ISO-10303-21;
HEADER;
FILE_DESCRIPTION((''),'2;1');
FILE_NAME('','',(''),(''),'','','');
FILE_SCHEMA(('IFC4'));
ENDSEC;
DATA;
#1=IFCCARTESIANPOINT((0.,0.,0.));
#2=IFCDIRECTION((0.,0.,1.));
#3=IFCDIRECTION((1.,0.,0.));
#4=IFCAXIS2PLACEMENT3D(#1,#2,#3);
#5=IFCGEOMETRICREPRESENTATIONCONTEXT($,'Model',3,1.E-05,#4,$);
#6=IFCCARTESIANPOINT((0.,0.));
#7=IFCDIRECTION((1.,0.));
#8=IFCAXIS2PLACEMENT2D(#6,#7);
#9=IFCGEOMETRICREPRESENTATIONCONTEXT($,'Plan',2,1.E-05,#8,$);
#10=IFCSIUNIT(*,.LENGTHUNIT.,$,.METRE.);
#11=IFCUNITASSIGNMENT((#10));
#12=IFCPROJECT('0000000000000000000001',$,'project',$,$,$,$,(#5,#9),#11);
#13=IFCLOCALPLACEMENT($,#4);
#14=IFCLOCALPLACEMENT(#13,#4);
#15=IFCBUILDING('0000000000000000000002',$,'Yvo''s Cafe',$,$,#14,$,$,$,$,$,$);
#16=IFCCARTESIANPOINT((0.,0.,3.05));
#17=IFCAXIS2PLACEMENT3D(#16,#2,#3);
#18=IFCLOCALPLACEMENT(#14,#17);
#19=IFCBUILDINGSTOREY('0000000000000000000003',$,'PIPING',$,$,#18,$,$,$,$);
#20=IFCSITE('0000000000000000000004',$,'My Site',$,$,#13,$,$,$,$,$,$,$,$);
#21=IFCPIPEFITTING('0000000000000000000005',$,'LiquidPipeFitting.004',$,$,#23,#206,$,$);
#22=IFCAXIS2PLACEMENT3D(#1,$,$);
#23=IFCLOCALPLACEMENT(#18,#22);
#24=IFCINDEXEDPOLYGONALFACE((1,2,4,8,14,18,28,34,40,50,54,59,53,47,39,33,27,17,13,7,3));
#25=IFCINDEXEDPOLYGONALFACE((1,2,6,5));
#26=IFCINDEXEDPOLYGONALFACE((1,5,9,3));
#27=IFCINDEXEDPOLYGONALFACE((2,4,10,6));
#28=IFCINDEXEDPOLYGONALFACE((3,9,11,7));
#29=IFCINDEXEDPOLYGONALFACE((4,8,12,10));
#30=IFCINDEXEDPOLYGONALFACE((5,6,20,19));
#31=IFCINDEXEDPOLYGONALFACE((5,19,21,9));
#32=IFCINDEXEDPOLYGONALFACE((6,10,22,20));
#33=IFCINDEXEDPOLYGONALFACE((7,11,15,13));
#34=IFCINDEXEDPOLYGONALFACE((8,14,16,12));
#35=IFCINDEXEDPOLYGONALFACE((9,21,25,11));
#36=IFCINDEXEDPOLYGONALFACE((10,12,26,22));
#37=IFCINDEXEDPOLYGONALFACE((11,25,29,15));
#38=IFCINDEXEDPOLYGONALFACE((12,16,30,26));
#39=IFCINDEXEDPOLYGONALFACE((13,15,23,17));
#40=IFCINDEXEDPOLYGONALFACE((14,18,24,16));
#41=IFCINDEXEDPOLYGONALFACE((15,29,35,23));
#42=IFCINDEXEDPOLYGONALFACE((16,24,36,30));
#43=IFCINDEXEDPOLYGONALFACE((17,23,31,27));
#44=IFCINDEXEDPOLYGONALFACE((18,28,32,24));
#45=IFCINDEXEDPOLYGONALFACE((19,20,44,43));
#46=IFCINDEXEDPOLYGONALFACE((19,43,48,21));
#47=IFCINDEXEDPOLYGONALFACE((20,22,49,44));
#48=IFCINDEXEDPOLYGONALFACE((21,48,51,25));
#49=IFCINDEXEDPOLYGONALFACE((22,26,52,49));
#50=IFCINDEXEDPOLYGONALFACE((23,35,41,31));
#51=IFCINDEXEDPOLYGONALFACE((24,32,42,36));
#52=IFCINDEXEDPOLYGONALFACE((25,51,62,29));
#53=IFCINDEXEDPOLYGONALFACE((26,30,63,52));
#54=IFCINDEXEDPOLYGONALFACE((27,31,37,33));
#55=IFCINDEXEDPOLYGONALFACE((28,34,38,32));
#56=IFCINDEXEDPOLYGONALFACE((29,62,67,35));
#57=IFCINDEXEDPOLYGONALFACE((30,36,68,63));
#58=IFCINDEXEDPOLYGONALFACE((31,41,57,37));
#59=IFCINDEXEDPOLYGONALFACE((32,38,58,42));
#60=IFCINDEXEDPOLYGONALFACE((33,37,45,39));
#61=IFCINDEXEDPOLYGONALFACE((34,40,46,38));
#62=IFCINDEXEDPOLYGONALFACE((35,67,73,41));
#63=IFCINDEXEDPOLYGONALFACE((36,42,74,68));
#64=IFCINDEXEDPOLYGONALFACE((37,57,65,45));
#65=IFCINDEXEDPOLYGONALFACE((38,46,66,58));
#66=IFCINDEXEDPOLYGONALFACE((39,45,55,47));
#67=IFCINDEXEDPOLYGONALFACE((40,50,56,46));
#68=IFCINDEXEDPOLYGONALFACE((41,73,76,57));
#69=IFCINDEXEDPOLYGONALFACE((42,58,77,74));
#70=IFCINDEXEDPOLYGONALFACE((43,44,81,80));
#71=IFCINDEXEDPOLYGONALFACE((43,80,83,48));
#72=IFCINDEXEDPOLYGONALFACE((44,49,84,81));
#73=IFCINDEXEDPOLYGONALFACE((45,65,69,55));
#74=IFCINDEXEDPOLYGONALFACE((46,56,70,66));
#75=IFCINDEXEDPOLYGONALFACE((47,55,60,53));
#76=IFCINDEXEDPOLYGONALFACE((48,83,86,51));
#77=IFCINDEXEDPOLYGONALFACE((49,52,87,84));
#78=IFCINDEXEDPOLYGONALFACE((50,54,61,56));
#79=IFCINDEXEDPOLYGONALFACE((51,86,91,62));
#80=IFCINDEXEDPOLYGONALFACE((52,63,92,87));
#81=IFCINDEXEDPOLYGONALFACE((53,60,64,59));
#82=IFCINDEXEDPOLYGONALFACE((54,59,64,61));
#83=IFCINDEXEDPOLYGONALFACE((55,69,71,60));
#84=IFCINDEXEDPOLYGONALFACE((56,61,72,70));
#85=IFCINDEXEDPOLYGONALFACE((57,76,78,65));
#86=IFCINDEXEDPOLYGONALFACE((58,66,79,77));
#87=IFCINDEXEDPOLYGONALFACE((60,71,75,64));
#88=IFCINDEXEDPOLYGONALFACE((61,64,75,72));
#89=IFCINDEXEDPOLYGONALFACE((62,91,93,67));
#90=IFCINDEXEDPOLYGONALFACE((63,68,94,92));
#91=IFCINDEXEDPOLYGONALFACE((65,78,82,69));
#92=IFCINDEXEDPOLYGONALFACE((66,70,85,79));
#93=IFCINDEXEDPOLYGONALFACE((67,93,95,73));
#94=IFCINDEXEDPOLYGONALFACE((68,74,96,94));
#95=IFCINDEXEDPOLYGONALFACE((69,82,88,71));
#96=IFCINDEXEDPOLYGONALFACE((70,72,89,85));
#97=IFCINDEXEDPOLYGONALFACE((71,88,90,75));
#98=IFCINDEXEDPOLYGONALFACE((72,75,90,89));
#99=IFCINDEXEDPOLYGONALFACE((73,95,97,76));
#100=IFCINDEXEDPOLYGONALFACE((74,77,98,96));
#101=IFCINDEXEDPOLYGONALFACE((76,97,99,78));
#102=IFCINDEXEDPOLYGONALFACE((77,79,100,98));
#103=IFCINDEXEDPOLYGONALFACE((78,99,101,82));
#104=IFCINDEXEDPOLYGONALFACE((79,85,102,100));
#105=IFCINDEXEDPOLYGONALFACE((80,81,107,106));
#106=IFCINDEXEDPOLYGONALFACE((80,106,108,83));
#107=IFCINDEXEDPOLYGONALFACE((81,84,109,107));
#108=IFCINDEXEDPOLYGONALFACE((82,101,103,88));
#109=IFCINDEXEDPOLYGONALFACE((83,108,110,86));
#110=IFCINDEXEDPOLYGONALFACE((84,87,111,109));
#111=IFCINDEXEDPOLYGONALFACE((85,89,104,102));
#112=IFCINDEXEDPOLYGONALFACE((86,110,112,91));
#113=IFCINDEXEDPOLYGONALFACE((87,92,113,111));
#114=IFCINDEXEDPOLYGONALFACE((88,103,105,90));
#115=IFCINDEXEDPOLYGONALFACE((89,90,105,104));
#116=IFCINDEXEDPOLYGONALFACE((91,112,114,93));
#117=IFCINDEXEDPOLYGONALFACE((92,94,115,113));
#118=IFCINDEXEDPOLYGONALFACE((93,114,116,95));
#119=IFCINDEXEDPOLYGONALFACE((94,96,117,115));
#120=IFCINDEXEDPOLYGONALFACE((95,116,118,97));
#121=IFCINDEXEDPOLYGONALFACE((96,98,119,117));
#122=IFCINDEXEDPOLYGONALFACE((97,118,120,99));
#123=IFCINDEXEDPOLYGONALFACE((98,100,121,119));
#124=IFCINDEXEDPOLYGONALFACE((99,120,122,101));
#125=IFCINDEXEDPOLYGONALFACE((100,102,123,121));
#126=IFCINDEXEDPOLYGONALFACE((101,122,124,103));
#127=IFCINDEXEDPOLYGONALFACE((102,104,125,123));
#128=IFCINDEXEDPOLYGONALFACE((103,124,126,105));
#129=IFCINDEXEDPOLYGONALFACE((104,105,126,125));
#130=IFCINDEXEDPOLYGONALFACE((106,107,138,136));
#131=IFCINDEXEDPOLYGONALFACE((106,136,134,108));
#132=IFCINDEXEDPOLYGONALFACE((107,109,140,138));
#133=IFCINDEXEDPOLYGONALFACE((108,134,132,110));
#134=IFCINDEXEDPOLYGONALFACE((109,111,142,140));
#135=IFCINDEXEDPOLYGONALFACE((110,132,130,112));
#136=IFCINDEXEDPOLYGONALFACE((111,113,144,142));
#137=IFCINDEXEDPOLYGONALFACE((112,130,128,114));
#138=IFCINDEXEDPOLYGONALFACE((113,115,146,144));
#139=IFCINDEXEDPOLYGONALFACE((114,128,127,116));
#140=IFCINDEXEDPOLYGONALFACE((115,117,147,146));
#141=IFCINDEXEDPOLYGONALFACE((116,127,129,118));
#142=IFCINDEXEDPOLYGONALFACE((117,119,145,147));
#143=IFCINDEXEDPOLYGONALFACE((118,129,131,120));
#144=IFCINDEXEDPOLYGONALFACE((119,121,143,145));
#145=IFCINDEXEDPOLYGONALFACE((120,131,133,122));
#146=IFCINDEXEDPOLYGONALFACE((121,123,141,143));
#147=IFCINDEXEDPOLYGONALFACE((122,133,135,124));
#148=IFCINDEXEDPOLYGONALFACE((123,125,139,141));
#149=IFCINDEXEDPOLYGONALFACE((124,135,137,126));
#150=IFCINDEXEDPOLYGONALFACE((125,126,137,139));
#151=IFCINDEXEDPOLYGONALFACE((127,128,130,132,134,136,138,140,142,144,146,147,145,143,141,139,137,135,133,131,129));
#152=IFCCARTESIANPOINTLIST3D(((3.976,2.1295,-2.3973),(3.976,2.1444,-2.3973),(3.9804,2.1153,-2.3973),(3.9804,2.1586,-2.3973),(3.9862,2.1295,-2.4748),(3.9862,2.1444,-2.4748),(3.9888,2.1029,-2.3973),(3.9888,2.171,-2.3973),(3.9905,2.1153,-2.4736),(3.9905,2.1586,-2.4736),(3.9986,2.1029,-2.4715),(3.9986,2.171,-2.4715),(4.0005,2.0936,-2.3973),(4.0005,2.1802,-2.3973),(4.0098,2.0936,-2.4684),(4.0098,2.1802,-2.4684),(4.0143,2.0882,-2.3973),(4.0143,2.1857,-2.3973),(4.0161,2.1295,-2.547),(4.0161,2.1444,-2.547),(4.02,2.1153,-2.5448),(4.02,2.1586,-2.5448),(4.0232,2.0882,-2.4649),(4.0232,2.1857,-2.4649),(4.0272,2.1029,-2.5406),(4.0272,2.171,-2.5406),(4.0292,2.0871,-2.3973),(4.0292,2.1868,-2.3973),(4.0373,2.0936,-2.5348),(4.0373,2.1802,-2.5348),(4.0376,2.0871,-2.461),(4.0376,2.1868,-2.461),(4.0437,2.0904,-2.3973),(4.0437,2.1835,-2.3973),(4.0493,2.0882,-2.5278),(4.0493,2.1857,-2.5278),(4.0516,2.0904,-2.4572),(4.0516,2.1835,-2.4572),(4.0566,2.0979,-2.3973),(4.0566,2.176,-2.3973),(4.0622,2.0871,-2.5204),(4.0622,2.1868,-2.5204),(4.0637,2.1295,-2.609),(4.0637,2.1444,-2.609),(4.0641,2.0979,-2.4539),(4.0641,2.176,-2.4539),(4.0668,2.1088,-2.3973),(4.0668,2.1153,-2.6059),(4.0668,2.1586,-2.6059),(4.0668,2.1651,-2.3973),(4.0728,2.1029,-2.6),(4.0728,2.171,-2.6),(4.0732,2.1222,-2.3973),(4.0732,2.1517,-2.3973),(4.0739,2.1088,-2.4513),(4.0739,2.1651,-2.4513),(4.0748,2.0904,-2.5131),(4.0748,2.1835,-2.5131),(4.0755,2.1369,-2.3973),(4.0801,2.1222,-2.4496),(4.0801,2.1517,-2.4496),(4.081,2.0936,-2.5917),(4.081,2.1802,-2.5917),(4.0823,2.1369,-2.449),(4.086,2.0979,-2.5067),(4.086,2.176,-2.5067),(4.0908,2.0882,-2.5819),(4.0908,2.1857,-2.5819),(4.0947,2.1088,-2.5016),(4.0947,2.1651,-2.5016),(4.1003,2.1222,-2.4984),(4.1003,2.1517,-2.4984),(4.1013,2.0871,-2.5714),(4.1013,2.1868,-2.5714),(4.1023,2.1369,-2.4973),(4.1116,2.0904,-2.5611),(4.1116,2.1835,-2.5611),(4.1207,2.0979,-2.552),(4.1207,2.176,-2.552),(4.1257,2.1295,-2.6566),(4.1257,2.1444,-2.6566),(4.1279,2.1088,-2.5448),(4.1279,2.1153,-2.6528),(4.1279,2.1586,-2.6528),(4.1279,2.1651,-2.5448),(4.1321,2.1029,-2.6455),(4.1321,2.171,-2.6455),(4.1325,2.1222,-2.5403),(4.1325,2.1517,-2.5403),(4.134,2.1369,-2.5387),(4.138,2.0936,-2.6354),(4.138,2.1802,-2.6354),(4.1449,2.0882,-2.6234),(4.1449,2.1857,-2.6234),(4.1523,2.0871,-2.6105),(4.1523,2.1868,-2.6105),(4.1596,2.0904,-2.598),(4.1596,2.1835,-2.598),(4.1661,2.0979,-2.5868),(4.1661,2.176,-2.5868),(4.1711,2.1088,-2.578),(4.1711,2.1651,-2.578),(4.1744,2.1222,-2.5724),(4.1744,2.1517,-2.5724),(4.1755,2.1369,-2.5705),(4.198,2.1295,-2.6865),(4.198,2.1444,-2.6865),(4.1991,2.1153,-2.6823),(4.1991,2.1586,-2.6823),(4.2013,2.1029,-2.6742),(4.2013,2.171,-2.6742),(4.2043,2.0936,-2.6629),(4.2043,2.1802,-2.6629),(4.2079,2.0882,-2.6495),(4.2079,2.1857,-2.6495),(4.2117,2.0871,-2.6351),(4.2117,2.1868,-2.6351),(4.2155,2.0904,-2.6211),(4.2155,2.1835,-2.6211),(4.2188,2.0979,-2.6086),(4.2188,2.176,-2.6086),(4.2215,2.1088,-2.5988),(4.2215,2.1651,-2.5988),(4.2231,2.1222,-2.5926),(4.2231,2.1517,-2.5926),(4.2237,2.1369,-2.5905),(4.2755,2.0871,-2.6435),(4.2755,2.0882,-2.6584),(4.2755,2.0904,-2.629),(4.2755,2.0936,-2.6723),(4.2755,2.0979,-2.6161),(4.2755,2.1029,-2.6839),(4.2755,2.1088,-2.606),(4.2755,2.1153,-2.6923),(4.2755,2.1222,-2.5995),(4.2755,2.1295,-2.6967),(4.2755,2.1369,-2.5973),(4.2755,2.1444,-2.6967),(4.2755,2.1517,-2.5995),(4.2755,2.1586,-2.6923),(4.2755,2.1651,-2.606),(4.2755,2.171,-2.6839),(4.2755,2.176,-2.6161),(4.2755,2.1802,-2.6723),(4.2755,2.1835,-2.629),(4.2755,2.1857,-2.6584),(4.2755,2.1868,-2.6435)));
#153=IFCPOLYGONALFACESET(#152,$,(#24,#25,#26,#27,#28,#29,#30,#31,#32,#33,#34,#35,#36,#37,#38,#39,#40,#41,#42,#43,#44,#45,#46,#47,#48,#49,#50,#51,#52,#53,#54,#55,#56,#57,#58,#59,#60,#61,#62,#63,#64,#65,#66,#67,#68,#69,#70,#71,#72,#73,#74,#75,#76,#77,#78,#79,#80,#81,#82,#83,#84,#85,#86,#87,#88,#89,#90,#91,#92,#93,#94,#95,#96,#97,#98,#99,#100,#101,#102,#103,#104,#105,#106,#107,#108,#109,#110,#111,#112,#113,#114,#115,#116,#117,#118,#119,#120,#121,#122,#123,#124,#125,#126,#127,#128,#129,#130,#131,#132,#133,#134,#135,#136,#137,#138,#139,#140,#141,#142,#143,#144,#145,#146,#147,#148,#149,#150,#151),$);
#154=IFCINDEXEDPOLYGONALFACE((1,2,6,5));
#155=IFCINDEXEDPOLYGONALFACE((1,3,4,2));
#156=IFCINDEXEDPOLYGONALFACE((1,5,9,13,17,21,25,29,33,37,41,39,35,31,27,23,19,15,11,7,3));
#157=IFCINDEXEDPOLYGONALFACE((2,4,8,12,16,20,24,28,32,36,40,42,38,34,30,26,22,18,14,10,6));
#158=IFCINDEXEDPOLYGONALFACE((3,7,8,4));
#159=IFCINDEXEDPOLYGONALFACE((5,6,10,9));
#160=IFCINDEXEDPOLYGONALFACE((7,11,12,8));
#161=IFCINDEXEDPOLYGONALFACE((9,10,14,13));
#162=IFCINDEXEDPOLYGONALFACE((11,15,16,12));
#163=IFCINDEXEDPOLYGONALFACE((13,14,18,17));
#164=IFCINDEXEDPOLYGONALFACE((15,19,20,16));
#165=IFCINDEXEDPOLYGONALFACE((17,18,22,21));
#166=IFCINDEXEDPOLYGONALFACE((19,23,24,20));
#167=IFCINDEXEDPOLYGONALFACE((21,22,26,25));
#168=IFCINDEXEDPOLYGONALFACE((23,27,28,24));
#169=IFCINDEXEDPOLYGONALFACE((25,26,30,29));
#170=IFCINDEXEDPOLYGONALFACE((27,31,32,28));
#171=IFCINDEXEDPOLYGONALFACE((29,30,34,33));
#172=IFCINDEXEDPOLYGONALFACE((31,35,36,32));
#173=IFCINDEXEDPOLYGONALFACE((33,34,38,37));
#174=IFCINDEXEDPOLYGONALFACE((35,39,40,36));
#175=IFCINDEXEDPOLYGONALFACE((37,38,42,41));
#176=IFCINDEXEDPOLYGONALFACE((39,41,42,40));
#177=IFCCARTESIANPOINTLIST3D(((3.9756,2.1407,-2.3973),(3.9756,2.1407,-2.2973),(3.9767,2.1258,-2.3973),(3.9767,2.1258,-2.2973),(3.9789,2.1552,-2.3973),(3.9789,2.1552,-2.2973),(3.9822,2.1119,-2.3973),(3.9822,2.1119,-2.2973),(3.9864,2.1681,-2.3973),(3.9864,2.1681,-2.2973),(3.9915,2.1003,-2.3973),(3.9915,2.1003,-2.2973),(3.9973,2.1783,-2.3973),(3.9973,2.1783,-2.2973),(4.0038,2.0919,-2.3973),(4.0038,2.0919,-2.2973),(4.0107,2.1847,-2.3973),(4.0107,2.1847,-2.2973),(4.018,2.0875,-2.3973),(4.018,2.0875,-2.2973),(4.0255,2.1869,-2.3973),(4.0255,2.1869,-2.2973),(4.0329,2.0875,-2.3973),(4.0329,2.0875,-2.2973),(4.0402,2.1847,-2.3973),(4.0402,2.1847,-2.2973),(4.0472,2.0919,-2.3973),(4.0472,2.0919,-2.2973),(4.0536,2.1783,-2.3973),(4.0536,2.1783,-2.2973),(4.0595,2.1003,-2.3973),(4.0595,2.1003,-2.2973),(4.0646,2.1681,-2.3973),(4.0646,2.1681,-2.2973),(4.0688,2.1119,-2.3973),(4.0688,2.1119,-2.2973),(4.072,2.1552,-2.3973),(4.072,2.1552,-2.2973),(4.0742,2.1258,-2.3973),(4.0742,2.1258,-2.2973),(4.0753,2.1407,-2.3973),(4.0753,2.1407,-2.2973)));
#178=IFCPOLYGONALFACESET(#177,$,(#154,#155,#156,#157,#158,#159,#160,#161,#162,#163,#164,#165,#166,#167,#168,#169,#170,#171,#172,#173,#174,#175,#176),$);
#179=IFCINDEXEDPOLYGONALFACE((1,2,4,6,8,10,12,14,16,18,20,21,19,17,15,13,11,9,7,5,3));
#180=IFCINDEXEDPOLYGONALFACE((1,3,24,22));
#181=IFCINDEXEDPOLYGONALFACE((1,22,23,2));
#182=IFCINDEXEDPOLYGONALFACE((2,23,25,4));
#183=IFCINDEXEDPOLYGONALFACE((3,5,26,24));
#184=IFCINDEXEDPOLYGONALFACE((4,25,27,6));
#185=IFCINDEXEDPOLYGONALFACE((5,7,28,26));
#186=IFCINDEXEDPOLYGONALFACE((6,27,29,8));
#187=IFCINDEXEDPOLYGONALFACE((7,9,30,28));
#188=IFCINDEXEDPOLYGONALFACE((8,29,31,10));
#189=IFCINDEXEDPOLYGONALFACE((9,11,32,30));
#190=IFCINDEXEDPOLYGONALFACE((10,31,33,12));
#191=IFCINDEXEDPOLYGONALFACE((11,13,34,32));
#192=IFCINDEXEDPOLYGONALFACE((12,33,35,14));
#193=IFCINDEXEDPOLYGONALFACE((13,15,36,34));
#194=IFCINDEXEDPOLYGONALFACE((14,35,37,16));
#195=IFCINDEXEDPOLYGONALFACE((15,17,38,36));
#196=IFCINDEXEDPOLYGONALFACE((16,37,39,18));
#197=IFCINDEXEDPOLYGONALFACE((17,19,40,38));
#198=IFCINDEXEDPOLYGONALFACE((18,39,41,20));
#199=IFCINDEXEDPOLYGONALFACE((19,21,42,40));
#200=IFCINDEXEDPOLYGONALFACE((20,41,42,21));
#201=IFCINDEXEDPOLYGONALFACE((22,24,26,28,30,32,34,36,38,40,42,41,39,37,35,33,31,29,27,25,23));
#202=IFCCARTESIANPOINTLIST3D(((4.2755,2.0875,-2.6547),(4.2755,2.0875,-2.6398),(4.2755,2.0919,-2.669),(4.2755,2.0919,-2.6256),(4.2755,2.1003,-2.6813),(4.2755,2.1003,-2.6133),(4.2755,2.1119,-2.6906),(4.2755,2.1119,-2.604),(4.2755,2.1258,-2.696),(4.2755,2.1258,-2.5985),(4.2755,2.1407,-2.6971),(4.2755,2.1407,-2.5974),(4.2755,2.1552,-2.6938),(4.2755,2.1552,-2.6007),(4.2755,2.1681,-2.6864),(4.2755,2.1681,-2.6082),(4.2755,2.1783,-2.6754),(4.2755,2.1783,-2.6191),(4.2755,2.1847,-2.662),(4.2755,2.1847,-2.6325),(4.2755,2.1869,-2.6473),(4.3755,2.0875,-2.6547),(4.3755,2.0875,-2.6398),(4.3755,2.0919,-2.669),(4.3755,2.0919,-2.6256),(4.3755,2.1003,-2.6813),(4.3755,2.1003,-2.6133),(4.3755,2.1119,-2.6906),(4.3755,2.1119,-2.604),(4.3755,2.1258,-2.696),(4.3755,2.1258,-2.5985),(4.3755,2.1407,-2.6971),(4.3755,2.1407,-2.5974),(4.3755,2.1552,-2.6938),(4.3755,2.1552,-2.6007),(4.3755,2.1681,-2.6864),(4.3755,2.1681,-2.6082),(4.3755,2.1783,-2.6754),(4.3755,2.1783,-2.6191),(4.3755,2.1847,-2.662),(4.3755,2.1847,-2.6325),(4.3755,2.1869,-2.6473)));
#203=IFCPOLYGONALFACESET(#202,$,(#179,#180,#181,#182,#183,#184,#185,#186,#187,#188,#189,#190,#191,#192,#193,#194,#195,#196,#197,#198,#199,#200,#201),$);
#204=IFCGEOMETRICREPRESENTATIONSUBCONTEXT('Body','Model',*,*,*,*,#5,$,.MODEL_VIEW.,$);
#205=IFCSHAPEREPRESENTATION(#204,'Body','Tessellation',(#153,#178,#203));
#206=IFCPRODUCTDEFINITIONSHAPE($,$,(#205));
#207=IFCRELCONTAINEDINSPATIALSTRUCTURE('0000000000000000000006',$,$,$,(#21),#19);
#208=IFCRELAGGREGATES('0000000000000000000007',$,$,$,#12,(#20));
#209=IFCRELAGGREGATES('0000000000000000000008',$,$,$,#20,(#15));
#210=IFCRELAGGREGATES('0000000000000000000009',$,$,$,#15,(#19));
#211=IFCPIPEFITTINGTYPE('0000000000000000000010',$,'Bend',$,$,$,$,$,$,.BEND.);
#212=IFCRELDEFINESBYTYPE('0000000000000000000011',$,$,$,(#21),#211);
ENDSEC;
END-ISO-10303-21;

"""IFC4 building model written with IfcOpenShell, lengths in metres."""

from ifc_helpers import new_model, entity, si_unit, frame, origin_with_axes, origin_2d_with_axis, place, context, subcontext, project, spatial, circle, extrude, source, transform, mapped, type_object, type_shapes, element, save


model = new_model("IFC4")

# Units and contexts
model_context = context("Model", 3, precision=1e-05, world=origin_with_axes())
plan_context = context("Plan", 2, precision=1e-05, world=origin_2d_with_axis())
body_context = subcontext(model_context, "Body", "Model", "MODEL_VIEW")
ifc_project = project(units=[si_unit("LENGTHUNIT", "METRE")], contexts=[model_context, plan_context])

# Site, building, storey
site_placement = place(None, origin_with_axes())
site = spatial("IfcSite", under=ifc_project, at=site_placement, Name="My Site")
building_placement = place(site_placement, origin_with_axes())
building = spatial("IfcBuilding", under=site, at=building_placement, Name="Yvo's Cafe")
storey_placement = place(building_placement, frame((0.0, 0.0, 3.05), z_axis=(0.0, 0.0, 1.0), x_axis=(1.0, 0.0, 0.0)))
storey = spatial("IfcBuildingStorey", under=building, at=storey_placement, Name="PIPING")

# Shared definitions
pipe_fitting_type_1 = type_object("IfcPipeFittingType", Name="Bend", PredefinedType="BEND")
shared_shape_1 = source(origin_with_axes(), body_context, "Body", "SolidModel", [
    entity("IfcSweptDiskSolid", entity("IfcIndexedPolyCurve", entity("IfcCartesianPointList3D", [[0.0, 0.0, -0.1], [0.0, -0.0732, -0.2768], [0.0, -0.25, -0.35]]), [entity("IfcArcIndex", [1, 2, 3])]), 0.05),
    extrude(circle(Radius=0.05), origin_with_axes(), (0.0, 0.0, -1.0), 0.1),
    extrude(circle(Radius=0.05), frame((0.0, -0.25, -0.35), z_axis=(0.0, -1.0, 0.0), x_axis=(1.0, 0.0, 0.0)), (0.0, 0.0, 1.0), 0.1),
])
type_shapes(pipe_fitting_type_1, [shared_shape_1])

# Pipe fitting
for number, where, z_axis, x_axis, name in (
    (1, (4.0255, 2.1369, -2.2973), (0.0, 0.0, 1.0), (0.0, 1.0, 0.0), "LiquidPipeFitting.004"),
):
    element("IfcPipeFitting", number, at=place(storey_placement, frame(where, z_axis=z_axis, x_axis=x_axis)), inside=storey, type_object=pipe_fitting_type_1, Name=name, context=body_context, shape_type="MappedRepresentation", body=[
        mapped(shared_shape_1, transform((0.0, 0.0, 0.0), x_axis=(1.0, 0.0, 0.0), y_axis=(0.0, 1.0, 0.0), z_axis=(0.0, 0.0, 1.0), scale=1.0)),
    ])

save(model, "model.ifc")
